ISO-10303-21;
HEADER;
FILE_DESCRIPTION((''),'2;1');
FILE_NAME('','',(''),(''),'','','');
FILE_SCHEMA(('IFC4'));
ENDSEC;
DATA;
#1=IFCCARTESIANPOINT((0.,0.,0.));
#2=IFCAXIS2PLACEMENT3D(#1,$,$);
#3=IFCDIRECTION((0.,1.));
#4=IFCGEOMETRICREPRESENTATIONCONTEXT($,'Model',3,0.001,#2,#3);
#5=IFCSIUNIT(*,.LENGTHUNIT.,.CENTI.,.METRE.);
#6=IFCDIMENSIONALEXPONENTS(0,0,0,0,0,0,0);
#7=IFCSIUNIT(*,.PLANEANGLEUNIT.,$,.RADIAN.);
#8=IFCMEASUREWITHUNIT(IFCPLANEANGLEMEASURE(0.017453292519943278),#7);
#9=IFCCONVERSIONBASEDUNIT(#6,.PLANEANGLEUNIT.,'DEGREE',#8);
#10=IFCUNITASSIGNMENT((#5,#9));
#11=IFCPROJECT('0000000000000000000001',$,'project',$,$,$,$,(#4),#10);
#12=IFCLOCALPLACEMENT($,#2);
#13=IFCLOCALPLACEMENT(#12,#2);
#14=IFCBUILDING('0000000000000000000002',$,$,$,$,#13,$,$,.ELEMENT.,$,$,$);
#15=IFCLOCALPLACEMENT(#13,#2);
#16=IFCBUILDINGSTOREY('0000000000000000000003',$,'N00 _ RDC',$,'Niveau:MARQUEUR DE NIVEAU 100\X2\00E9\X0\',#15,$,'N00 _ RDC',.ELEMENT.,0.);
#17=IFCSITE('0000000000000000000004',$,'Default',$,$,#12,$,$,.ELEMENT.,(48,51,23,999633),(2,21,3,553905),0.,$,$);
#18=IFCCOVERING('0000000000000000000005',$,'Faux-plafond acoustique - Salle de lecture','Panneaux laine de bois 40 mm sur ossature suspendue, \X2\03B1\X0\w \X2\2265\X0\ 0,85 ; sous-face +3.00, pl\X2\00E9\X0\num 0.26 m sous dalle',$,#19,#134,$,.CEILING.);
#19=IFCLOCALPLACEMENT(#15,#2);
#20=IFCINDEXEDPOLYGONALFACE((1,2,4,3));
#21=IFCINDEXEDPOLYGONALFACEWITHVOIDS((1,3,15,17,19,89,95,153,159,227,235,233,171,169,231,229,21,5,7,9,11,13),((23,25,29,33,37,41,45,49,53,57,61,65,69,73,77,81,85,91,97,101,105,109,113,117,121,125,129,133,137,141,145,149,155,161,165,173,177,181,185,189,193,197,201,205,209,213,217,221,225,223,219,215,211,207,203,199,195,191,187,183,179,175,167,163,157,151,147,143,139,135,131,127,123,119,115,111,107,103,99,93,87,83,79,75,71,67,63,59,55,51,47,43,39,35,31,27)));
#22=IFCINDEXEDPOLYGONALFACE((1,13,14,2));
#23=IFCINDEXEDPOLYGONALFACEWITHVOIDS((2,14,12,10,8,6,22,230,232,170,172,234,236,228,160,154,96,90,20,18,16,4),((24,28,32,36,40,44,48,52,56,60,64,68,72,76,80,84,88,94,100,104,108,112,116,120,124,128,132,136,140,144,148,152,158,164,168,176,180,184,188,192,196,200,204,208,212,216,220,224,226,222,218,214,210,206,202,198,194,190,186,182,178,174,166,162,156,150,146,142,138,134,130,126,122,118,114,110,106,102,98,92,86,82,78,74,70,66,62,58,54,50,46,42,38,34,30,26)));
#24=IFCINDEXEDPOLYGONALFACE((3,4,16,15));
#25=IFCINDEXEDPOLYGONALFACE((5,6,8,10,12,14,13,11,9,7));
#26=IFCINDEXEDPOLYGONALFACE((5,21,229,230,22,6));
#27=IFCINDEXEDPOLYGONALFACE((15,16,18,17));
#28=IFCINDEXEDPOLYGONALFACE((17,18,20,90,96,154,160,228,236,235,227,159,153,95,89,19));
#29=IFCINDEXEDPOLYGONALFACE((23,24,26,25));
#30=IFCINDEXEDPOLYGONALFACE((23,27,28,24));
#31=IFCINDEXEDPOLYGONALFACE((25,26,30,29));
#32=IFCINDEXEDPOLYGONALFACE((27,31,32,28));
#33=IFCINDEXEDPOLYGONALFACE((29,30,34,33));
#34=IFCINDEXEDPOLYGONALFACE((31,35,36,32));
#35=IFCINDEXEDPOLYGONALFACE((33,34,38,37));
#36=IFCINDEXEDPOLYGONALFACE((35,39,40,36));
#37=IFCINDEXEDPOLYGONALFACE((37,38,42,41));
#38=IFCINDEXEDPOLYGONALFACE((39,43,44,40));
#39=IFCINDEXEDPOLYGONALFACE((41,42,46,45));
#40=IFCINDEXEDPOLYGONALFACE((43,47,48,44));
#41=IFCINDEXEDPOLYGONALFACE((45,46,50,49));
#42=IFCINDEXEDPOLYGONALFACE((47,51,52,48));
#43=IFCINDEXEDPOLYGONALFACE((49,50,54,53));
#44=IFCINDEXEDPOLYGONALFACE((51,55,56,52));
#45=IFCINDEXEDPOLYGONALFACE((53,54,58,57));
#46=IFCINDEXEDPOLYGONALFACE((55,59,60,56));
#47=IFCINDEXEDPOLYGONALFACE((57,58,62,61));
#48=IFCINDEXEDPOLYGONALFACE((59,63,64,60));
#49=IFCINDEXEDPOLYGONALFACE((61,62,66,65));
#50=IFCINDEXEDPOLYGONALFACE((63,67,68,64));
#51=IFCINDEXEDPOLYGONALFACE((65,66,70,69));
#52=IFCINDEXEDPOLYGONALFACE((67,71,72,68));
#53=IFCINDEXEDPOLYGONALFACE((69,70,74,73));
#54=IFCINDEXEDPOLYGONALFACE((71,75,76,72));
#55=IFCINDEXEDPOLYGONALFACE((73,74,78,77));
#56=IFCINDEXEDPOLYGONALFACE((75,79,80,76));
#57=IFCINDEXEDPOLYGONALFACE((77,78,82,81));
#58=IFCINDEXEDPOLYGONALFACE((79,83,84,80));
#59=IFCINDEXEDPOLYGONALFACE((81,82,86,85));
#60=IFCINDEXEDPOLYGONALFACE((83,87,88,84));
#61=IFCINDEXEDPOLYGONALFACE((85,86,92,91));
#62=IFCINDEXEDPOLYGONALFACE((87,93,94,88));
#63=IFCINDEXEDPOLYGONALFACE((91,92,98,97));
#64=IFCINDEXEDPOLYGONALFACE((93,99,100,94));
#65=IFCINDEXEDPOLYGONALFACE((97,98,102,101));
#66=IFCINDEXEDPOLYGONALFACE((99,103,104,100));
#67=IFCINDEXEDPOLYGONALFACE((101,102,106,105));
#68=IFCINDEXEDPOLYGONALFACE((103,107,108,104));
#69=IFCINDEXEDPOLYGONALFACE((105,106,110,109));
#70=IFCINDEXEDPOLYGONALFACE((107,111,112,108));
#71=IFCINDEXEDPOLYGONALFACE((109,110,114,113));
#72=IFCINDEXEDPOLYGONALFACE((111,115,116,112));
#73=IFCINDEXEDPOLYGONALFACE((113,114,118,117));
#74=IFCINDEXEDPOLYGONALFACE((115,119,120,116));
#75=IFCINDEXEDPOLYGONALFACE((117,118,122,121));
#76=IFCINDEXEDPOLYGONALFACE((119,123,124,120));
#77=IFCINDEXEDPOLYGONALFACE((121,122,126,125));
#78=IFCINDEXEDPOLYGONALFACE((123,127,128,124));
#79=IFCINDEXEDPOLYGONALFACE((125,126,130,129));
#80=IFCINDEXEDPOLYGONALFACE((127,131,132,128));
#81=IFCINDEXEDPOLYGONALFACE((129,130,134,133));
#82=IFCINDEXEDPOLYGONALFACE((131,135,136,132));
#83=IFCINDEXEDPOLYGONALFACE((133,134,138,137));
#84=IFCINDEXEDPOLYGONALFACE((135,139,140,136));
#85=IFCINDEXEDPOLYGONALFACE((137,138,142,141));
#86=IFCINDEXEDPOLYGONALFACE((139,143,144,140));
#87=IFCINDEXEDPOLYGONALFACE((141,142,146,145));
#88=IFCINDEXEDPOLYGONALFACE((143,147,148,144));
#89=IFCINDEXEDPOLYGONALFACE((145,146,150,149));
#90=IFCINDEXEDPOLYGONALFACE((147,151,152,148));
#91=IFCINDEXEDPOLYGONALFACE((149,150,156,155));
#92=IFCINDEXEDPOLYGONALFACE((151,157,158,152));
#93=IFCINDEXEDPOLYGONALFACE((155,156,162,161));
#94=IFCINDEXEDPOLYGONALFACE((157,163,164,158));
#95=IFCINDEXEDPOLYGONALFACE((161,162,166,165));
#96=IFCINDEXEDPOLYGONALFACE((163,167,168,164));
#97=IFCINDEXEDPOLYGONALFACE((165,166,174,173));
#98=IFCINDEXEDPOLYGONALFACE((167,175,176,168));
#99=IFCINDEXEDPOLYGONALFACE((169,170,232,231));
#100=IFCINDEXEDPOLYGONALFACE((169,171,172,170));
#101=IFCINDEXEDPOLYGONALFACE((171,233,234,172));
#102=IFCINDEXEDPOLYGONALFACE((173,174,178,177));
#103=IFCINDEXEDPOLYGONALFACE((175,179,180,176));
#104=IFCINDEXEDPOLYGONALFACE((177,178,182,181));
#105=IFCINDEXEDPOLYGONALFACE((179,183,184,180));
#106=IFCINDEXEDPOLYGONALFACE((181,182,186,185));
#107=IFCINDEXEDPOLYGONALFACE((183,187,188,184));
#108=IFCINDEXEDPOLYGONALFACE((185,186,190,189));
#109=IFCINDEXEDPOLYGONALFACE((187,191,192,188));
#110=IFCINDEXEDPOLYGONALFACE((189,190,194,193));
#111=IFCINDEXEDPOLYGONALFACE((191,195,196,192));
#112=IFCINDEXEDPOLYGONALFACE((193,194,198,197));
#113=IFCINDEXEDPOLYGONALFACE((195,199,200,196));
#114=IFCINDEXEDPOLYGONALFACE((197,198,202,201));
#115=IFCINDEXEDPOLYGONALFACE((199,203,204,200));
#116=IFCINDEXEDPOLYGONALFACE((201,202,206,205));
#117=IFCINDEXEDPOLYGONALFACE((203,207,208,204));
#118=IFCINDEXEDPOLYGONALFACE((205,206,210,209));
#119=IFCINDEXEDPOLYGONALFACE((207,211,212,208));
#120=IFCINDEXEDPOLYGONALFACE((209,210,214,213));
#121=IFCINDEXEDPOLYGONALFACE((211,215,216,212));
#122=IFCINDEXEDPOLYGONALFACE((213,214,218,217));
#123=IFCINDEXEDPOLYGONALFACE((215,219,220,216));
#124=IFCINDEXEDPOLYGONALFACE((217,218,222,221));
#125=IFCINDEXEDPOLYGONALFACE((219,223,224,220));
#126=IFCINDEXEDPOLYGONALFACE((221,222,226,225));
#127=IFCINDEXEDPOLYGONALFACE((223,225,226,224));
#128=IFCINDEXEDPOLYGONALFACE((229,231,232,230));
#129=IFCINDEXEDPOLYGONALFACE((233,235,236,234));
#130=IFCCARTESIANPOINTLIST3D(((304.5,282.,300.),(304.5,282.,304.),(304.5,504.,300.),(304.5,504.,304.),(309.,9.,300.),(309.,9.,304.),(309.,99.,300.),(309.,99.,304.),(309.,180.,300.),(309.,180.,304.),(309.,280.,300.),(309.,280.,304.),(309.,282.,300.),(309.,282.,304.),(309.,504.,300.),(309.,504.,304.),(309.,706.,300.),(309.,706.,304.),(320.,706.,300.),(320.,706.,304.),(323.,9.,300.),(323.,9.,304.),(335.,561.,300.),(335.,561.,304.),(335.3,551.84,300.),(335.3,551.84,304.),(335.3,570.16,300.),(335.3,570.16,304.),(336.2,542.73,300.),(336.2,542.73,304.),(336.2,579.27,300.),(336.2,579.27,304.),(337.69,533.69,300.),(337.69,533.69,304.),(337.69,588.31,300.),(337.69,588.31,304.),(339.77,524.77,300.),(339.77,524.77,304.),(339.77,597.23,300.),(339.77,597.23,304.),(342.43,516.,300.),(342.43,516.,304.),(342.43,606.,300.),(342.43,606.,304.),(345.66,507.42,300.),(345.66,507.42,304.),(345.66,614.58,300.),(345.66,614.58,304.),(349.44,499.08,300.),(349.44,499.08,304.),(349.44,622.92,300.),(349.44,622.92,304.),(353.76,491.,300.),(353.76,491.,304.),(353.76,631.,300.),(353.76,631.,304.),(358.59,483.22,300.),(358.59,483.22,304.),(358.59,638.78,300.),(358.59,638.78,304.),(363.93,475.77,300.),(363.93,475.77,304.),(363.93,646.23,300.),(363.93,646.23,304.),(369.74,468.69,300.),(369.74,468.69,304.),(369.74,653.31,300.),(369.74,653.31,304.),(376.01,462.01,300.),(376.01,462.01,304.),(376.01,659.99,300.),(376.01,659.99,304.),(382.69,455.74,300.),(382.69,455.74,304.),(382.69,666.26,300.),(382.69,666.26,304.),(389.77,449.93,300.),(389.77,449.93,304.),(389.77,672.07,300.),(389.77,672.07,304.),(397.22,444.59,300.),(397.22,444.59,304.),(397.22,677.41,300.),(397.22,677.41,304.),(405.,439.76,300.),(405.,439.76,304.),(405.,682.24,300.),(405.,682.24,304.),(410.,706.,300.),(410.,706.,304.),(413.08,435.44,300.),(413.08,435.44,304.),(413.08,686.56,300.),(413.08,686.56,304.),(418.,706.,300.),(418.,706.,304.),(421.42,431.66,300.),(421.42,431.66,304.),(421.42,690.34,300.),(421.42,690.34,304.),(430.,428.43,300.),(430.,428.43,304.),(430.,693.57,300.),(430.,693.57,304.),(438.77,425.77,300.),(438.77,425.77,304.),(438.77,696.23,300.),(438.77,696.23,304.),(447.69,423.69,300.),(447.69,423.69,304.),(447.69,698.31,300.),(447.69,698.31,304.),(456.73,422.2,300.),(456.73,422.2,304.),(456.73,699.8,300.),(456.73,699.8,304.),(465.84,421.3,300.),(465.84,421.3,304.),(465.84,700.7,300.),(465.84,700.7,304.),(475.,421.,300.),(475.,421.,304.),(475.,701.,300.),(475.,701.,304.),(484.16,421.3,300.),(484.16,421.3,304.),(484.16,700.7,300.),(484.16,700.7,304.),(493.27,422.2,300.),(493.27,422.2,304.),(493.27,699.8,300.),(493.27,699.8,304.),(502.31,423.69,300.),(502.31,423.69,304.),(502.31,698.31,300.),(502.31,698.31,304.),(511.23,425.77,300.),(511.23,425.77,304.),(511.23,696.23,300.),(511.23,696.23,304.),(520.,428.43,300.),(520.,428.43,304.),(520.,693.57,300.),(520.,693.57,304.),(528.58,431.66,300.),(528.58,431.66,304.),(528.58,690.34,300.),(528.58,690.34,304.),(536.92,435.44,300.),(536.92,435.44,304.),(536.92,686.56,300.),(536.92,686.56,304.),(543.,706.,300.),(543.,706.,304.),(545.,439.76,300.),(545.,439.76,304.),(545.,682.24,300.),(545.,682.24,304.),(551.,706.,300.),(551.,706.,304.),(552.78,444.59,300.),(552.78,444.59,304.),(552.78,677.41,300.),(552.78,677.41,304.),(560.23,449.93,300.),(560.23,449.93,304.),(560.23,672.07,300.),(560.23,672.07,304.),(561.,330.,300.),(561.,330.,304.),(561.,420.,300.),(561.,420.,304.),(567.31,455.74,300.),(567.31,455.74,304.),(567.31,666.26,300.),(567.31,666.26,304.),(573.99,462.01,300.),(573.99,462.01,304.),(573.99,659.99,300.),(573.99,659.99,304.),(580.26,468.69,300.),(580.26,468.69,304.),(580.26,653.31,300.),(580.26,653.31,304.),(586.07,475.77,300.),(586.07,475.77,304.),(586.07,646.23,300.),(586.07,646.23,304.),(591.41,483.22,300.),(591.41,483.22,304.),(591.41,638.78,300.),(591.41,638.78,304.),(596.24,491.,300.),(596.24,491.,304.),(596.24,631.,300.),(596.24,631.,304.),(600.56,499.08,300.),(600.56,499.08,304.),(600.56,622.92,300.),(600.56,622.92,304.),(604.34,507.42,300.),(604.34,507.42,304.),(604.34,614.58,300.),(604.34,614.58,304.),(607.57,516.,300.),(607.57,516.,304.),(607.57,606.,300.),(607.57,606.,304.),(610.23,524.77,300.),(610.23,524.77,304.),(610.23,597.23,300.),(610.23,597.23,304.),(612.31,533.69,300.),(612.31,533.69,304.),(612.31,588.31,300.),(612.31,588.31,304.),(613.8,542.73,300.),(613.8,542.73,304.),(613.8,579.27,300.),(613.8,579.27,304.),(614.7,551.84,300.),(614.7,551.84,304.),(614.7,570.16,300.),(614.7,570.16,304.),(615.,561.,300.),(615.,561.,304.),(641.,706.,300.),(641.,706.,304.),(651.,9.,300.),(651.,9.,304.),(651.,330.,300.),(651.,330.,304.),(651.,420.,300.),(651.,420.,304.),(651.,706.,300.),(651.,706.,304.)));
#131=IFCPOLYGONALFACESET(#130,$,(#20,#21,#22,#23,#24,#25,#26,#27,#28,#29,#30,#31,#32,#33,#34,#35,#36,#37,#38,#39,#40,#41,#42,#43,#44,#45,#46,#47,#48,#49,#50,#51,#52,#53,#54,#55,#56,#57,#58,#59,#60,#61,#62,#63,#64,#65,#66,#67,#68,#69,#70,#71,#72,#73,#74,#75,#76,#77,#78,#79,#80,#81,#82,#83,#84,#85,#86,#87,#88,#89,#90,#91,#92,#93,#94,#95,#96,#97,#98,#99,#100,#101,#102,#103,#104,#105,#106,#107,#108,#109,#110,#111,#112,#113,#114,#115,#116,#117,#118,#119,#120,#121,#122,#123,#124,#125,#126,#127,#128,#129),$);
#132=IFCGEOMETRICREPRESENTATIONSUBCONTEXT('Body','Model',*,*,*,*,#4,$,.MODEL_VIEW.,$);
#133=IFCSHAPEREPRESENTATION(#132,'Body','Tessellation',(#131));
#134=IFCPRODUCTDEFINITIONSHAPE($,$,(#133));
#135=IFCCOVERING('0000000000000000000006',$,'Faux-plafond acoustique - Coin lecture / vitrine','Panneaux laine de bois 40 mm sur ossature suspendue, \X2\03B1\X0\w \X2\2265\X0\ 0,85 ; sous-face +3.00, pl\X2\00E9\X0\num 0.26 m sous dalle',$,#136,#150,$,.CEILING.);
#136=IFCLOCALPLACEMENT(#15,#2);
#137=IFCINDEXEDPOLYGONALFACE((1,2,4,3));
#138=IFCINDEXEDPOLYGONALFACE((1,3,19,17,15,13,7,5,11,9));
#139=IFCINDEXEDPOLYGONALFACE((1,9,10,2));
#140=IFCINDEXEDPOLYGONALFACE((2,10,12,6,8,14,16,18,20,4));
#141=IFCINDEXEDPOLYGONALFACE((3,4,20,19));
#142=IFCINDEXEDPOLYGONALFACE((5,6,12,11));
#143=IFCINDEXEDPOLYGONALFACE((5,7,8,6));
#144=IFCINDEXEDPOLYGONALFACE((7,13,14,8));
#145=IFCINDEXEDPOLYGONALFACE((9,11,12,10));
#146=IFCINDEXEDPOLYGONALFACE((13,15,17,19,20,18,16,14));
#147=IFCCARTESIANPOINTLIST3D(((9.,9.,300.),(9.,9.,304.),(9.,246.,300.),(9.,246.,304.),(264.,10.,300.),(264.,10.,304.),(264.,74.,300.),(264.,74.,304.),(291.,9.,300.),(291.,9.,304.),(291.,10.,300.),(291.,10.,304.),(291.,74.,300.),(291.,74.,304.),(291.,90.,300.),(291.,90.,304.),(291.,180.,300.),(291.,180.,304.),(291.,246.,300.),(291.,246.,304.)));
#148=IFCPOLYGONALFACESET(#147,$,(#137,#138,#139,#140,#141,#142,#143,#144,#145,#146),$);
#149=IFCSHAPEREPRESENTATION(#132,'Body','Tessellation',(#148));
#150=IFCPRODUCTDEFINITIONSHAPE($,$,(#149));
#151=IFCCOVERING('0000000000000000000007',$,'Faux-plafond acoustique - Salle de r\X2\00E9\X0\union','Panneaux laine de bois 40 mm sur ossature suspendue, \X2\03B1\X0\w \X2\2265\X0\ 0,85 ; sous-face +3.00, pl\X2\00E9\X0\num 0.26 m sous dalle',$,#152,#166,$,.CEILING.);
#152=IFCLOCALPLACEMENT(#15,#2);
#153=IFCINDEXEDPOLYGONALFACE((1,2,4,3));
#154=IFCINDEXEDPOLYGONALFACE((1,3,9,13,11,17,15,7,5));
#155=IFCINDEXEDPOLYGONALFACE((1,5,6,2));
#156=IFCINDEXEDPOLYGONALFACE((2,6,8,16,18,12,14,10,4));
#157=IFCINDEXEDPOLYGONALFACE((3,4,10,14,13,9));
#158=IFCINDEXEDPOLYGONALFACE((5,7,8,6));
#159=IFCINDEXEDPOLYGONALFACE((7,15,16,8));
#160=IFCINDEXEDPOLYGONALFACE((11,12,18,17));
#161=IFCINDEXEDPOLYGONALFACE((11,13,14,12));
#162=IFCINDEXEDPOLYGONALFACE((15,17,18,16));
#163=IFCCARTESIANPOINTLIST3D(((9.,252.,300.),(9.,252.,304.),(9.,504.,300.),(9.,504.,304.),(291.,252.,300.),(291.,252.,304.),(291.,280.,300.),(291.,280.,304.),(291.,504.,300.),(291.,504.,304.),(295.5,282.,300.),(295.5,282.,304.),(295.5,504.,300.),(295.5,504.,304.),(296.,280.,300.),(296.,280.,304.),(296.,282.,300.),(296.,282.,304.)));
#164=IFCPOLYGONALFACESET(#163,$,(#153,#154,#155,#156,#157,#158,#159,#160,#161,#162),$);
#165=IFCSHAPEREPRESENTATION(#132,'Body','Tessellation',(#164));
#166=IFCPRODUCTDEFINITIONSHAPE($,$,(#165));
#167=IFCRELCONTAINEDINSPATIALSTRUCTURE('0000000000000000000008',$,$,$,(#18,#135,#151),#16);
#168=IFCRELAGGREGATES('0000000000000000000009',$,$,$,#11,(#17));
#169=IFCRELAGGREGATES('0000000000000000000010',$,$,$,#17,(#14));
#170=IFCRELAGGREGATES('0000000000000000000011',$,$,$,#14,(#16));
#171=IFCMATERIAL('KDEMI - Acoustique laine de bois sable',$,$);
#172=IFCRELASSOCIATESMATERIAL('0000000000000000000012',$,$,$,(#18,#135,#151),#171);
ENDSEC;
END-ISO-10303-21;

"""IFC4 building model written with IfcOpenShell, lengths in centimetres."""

from ifc_helpers import new_model, entity, si_unit, converted_unit, direction, frame, origin, origin_with_axes, place, context, subcontext, project, spatial, polyline, outline, extrude, material, element, save


model = new_model("IFC4")

# Units and contexts
model_context = context("Model", 3, precision=0.001, world=origin(), true_north=direction((0.0, 1.0)))
body_context = subcontext(model_context, "Body", "Model", "MODEL_VIEW")
ifc_project = project(units=[si_unit("LENGTHUNIT", "METRE", prefix="CENTI"), converted_unit("PLANEANGLEUNIT", "DEGREE", entity("IfcPlaneAngleMeasure", 0.017453292519943278), si_unit("PLANEANGLEUNIT", "RADIAN"), dimensions=[0, 0, 0, 0, 0, 0, 0])], contexts=[model_context])

# Site, building, storey
site_placement = place(None, origin())
site = spatial("IfcSite", under=ifc_project, at=site_placement, Name="Default", CompositionType="ELEMENT", RefLatitude=(48, 51, 23, 999633), RefLongitude=(2, 21, 3, 553905), RefElevation=0.0)
building_placement = place(site_placement, origin())
building = spatial("IfcBuilding", under=site, at=building_placement, CompositionType="ELEMENT")
storey_placement = place(building_placement, origin())
storey = spatial("IfcBuildingStorey", under=building, at=storey_placement, Name="N00 _ RDC", ObjectType="Niveau:MARQUEUR DE NIVEAU 100é", LongName="N00 _ RDC", CompositionType="ELEMENT", Elevation=0.0)

# Coverings
ifc_material_1 = material(Name="KDEMI - Acoustique laine de bois sable")
covering_1_placement = place(storey_placement, origin_with_axes())
element("IfcCovering", 1, at=covering_1_placement, inside=storey, material=ifc_material_1, Name="Faux-plafond acoustique - Salle de lecture", Description="Panneaux laine de bois 40 mm sur ossature suspendue, αw ≥ 0,85 ; sous-face +3.00, plénum 0.26 m sous dalle", PredefinedType="CEILING", context=body_context, shape_type="SweptSolid", body=[
    extrude(outline(polyline([(651.0, 706.0), (651.0, 420.0), (561.0, 420.0), (561.0, 330.0), (651.0, 330.0), (651.0, 9.0), (651.0, 9.0), (651.0, 9.0), (323.0, 9.0), (323.0, 9.0), (309.0, 9.0), (309.0, 99.0), (309.0, 180.0), (309.0, 180.0), (309.0, 280.0), (309.0, 280.0), (309.0, 282.0), (304.0, 282.0), (304.0, 282.0), (304.5, 282.0), (304.5, 504.0), (309.0, 504.0), (309.0, 504.0), (309.0, 706.0), (320.0, 706.0), (410.0, 706.0), (418.0, 706.0), (543.0, 706.0), (551.0, 706.0), (641.0, 706.0), (651.0, 706.0)]), holes=[polyline([(610.23, 597.23), (607.57, 606.0), (604.34, 614.58), (600.56, 622.92), (596.24, 631.0), (591.41, 638.78), (586.07, 646.23), (580.26, 653.31), (573.99, 659.99), (567.31, 666.26), (560.23, 672.07), (552.78, 677.41), (545.0, 682.24), (536.92, 686.56), (528.58, 690.34), (520.0, 693.57), (511.23, 696.23), (502.31, 698.31), (493.27, 699.8), (484.16, 700.7), (475.0, 701.0), (465.84, 700.7), (456.73, 699.8), (447.69, 698.31), (438.77, 696.23), (430.0, 693.57), (421.42, 690.34), (413.08, 686.56), (405.0, 682.24), (397.22, 677.41), (389.77, 672.07), (382.69, 666.26), (376.01, 659.99), (369.74, 653.31), (363.93, 646.23), (358.59, 638.78), (353.76, 631.0), (349.44, 622.92), (345.66, 614.58), (342.43, 606.0), (339.77, 597.23), (337.69, 588.31), (336.2, 579.27), (335.3, 570.16), (335.0, 561.0), (335.3, 551.84), (336.2, 542.73), (337.69, 533.69), (339.77, 524.77), (342.43, 516.0), (345.66, 507.42), (349.44, 499.08), (353.76, 491.0), (358.59, 483.22), (363.93, 475.77), (369.74, 468.69), (376.01, 462.01), (382.69, 455.74), (389.77, 449.93), (397.22, 444.59), (405.0, 439.76), (413.08, 435.44), (421.42, 431.66), (430.0, 428.43), (438.77, 425.77), (447.69, 423.69), (456.73, 422.2), (465.84, 421.3), (475.0, 421.0), (484.16, 421.3), (493.27, 422.2), (502.31, 423.69), (511.23, 425.77), (520.0, 428.43), (528.58, 431.66), (536.92, 435.44), (545.0, 439.76), (552.78, 444.59), (560.23, 449.93), (567.31, 455.74), (573.99, 462.01), (580.26, 468.69), (586.07, 475.77), (591.41, 483.22), (596.24, 491.0), (600.56, 499.08), (604.34, 507.42), (607.57, 516.0), (610.23, 524.77), (612.31, 533.69), (613.8, 542.73), (614.7, 551.84), (615.0, 561.0), (614.7, 570.16), (613.8, 579.27), (612.31, 588.31), (610.23, 597.23)])]), frame((0.0, 0.0, 300.0)), (0.0, 0.0, 1.0), 4.0),
])
covering_2_placement = place(storey_placement, origin_with_axes())
element("IfcCovering", 2, at=covering_2_placement, inside=storey, material=ifc_material_1, Name="Faux-plafond acoustique - Coin lecture / vitrine", Description="Panneaux laine de bois 40 mm sur ossature suspendue, αw ≥ 0,85 ; sous-face +3.00, plénum 0.26 m sous dalle", PredefinedType="CEILING", context=body_context, shape_type="SweptSolid", body=[
    extrude(outline(polyline([(291.0, 90.0), (291.0, 74.0), (264.0, 74.0), (264.0, 10.0), (291.0, 10.0), (291.0, 9.0), (9.0, 9.0), (9.0, 246.0), (291.0, 246.0), (291.0, 180.0), (291.0, 180.0), (291.0, 90.0), (291.0, 90.0)])), frame((0.0, 0.0, 300.0)), (0.0, 0.0, 1.0), 4.0),
])
covering_3_placement = place(storey_placement, origin_with_axes())
element("IfcCovering", 3, at=covering_3_placement, inside=storey, material=ifc_material_1, Name="Faux-plafond acoustique - Salle de réunion", Description="Panneaux laine de bois 40 mm sur ossature suspendue, αw ≥ 0,85 ; sous-face +3.00, plénum 0.26 m sous dalle", PredefinedType="CEILING", context=body_context, shape_type="SweptSolid", body=[
    extrude(outline(polyline([(296.0, 280.0), (291.0, 280.0), (291.0, 252.0), (9.0, 252.0), (9.0, 504.0), (291.0, 504.0), (295.5, 504.0), (295.5, 282.0), (296.0, 282.0), (296.0, 280.0)])), frame((0.0, 0.0, 300.0)), (0.0, 0.0, 1.0), 4.0),
])

save(model, "model.ifc")
